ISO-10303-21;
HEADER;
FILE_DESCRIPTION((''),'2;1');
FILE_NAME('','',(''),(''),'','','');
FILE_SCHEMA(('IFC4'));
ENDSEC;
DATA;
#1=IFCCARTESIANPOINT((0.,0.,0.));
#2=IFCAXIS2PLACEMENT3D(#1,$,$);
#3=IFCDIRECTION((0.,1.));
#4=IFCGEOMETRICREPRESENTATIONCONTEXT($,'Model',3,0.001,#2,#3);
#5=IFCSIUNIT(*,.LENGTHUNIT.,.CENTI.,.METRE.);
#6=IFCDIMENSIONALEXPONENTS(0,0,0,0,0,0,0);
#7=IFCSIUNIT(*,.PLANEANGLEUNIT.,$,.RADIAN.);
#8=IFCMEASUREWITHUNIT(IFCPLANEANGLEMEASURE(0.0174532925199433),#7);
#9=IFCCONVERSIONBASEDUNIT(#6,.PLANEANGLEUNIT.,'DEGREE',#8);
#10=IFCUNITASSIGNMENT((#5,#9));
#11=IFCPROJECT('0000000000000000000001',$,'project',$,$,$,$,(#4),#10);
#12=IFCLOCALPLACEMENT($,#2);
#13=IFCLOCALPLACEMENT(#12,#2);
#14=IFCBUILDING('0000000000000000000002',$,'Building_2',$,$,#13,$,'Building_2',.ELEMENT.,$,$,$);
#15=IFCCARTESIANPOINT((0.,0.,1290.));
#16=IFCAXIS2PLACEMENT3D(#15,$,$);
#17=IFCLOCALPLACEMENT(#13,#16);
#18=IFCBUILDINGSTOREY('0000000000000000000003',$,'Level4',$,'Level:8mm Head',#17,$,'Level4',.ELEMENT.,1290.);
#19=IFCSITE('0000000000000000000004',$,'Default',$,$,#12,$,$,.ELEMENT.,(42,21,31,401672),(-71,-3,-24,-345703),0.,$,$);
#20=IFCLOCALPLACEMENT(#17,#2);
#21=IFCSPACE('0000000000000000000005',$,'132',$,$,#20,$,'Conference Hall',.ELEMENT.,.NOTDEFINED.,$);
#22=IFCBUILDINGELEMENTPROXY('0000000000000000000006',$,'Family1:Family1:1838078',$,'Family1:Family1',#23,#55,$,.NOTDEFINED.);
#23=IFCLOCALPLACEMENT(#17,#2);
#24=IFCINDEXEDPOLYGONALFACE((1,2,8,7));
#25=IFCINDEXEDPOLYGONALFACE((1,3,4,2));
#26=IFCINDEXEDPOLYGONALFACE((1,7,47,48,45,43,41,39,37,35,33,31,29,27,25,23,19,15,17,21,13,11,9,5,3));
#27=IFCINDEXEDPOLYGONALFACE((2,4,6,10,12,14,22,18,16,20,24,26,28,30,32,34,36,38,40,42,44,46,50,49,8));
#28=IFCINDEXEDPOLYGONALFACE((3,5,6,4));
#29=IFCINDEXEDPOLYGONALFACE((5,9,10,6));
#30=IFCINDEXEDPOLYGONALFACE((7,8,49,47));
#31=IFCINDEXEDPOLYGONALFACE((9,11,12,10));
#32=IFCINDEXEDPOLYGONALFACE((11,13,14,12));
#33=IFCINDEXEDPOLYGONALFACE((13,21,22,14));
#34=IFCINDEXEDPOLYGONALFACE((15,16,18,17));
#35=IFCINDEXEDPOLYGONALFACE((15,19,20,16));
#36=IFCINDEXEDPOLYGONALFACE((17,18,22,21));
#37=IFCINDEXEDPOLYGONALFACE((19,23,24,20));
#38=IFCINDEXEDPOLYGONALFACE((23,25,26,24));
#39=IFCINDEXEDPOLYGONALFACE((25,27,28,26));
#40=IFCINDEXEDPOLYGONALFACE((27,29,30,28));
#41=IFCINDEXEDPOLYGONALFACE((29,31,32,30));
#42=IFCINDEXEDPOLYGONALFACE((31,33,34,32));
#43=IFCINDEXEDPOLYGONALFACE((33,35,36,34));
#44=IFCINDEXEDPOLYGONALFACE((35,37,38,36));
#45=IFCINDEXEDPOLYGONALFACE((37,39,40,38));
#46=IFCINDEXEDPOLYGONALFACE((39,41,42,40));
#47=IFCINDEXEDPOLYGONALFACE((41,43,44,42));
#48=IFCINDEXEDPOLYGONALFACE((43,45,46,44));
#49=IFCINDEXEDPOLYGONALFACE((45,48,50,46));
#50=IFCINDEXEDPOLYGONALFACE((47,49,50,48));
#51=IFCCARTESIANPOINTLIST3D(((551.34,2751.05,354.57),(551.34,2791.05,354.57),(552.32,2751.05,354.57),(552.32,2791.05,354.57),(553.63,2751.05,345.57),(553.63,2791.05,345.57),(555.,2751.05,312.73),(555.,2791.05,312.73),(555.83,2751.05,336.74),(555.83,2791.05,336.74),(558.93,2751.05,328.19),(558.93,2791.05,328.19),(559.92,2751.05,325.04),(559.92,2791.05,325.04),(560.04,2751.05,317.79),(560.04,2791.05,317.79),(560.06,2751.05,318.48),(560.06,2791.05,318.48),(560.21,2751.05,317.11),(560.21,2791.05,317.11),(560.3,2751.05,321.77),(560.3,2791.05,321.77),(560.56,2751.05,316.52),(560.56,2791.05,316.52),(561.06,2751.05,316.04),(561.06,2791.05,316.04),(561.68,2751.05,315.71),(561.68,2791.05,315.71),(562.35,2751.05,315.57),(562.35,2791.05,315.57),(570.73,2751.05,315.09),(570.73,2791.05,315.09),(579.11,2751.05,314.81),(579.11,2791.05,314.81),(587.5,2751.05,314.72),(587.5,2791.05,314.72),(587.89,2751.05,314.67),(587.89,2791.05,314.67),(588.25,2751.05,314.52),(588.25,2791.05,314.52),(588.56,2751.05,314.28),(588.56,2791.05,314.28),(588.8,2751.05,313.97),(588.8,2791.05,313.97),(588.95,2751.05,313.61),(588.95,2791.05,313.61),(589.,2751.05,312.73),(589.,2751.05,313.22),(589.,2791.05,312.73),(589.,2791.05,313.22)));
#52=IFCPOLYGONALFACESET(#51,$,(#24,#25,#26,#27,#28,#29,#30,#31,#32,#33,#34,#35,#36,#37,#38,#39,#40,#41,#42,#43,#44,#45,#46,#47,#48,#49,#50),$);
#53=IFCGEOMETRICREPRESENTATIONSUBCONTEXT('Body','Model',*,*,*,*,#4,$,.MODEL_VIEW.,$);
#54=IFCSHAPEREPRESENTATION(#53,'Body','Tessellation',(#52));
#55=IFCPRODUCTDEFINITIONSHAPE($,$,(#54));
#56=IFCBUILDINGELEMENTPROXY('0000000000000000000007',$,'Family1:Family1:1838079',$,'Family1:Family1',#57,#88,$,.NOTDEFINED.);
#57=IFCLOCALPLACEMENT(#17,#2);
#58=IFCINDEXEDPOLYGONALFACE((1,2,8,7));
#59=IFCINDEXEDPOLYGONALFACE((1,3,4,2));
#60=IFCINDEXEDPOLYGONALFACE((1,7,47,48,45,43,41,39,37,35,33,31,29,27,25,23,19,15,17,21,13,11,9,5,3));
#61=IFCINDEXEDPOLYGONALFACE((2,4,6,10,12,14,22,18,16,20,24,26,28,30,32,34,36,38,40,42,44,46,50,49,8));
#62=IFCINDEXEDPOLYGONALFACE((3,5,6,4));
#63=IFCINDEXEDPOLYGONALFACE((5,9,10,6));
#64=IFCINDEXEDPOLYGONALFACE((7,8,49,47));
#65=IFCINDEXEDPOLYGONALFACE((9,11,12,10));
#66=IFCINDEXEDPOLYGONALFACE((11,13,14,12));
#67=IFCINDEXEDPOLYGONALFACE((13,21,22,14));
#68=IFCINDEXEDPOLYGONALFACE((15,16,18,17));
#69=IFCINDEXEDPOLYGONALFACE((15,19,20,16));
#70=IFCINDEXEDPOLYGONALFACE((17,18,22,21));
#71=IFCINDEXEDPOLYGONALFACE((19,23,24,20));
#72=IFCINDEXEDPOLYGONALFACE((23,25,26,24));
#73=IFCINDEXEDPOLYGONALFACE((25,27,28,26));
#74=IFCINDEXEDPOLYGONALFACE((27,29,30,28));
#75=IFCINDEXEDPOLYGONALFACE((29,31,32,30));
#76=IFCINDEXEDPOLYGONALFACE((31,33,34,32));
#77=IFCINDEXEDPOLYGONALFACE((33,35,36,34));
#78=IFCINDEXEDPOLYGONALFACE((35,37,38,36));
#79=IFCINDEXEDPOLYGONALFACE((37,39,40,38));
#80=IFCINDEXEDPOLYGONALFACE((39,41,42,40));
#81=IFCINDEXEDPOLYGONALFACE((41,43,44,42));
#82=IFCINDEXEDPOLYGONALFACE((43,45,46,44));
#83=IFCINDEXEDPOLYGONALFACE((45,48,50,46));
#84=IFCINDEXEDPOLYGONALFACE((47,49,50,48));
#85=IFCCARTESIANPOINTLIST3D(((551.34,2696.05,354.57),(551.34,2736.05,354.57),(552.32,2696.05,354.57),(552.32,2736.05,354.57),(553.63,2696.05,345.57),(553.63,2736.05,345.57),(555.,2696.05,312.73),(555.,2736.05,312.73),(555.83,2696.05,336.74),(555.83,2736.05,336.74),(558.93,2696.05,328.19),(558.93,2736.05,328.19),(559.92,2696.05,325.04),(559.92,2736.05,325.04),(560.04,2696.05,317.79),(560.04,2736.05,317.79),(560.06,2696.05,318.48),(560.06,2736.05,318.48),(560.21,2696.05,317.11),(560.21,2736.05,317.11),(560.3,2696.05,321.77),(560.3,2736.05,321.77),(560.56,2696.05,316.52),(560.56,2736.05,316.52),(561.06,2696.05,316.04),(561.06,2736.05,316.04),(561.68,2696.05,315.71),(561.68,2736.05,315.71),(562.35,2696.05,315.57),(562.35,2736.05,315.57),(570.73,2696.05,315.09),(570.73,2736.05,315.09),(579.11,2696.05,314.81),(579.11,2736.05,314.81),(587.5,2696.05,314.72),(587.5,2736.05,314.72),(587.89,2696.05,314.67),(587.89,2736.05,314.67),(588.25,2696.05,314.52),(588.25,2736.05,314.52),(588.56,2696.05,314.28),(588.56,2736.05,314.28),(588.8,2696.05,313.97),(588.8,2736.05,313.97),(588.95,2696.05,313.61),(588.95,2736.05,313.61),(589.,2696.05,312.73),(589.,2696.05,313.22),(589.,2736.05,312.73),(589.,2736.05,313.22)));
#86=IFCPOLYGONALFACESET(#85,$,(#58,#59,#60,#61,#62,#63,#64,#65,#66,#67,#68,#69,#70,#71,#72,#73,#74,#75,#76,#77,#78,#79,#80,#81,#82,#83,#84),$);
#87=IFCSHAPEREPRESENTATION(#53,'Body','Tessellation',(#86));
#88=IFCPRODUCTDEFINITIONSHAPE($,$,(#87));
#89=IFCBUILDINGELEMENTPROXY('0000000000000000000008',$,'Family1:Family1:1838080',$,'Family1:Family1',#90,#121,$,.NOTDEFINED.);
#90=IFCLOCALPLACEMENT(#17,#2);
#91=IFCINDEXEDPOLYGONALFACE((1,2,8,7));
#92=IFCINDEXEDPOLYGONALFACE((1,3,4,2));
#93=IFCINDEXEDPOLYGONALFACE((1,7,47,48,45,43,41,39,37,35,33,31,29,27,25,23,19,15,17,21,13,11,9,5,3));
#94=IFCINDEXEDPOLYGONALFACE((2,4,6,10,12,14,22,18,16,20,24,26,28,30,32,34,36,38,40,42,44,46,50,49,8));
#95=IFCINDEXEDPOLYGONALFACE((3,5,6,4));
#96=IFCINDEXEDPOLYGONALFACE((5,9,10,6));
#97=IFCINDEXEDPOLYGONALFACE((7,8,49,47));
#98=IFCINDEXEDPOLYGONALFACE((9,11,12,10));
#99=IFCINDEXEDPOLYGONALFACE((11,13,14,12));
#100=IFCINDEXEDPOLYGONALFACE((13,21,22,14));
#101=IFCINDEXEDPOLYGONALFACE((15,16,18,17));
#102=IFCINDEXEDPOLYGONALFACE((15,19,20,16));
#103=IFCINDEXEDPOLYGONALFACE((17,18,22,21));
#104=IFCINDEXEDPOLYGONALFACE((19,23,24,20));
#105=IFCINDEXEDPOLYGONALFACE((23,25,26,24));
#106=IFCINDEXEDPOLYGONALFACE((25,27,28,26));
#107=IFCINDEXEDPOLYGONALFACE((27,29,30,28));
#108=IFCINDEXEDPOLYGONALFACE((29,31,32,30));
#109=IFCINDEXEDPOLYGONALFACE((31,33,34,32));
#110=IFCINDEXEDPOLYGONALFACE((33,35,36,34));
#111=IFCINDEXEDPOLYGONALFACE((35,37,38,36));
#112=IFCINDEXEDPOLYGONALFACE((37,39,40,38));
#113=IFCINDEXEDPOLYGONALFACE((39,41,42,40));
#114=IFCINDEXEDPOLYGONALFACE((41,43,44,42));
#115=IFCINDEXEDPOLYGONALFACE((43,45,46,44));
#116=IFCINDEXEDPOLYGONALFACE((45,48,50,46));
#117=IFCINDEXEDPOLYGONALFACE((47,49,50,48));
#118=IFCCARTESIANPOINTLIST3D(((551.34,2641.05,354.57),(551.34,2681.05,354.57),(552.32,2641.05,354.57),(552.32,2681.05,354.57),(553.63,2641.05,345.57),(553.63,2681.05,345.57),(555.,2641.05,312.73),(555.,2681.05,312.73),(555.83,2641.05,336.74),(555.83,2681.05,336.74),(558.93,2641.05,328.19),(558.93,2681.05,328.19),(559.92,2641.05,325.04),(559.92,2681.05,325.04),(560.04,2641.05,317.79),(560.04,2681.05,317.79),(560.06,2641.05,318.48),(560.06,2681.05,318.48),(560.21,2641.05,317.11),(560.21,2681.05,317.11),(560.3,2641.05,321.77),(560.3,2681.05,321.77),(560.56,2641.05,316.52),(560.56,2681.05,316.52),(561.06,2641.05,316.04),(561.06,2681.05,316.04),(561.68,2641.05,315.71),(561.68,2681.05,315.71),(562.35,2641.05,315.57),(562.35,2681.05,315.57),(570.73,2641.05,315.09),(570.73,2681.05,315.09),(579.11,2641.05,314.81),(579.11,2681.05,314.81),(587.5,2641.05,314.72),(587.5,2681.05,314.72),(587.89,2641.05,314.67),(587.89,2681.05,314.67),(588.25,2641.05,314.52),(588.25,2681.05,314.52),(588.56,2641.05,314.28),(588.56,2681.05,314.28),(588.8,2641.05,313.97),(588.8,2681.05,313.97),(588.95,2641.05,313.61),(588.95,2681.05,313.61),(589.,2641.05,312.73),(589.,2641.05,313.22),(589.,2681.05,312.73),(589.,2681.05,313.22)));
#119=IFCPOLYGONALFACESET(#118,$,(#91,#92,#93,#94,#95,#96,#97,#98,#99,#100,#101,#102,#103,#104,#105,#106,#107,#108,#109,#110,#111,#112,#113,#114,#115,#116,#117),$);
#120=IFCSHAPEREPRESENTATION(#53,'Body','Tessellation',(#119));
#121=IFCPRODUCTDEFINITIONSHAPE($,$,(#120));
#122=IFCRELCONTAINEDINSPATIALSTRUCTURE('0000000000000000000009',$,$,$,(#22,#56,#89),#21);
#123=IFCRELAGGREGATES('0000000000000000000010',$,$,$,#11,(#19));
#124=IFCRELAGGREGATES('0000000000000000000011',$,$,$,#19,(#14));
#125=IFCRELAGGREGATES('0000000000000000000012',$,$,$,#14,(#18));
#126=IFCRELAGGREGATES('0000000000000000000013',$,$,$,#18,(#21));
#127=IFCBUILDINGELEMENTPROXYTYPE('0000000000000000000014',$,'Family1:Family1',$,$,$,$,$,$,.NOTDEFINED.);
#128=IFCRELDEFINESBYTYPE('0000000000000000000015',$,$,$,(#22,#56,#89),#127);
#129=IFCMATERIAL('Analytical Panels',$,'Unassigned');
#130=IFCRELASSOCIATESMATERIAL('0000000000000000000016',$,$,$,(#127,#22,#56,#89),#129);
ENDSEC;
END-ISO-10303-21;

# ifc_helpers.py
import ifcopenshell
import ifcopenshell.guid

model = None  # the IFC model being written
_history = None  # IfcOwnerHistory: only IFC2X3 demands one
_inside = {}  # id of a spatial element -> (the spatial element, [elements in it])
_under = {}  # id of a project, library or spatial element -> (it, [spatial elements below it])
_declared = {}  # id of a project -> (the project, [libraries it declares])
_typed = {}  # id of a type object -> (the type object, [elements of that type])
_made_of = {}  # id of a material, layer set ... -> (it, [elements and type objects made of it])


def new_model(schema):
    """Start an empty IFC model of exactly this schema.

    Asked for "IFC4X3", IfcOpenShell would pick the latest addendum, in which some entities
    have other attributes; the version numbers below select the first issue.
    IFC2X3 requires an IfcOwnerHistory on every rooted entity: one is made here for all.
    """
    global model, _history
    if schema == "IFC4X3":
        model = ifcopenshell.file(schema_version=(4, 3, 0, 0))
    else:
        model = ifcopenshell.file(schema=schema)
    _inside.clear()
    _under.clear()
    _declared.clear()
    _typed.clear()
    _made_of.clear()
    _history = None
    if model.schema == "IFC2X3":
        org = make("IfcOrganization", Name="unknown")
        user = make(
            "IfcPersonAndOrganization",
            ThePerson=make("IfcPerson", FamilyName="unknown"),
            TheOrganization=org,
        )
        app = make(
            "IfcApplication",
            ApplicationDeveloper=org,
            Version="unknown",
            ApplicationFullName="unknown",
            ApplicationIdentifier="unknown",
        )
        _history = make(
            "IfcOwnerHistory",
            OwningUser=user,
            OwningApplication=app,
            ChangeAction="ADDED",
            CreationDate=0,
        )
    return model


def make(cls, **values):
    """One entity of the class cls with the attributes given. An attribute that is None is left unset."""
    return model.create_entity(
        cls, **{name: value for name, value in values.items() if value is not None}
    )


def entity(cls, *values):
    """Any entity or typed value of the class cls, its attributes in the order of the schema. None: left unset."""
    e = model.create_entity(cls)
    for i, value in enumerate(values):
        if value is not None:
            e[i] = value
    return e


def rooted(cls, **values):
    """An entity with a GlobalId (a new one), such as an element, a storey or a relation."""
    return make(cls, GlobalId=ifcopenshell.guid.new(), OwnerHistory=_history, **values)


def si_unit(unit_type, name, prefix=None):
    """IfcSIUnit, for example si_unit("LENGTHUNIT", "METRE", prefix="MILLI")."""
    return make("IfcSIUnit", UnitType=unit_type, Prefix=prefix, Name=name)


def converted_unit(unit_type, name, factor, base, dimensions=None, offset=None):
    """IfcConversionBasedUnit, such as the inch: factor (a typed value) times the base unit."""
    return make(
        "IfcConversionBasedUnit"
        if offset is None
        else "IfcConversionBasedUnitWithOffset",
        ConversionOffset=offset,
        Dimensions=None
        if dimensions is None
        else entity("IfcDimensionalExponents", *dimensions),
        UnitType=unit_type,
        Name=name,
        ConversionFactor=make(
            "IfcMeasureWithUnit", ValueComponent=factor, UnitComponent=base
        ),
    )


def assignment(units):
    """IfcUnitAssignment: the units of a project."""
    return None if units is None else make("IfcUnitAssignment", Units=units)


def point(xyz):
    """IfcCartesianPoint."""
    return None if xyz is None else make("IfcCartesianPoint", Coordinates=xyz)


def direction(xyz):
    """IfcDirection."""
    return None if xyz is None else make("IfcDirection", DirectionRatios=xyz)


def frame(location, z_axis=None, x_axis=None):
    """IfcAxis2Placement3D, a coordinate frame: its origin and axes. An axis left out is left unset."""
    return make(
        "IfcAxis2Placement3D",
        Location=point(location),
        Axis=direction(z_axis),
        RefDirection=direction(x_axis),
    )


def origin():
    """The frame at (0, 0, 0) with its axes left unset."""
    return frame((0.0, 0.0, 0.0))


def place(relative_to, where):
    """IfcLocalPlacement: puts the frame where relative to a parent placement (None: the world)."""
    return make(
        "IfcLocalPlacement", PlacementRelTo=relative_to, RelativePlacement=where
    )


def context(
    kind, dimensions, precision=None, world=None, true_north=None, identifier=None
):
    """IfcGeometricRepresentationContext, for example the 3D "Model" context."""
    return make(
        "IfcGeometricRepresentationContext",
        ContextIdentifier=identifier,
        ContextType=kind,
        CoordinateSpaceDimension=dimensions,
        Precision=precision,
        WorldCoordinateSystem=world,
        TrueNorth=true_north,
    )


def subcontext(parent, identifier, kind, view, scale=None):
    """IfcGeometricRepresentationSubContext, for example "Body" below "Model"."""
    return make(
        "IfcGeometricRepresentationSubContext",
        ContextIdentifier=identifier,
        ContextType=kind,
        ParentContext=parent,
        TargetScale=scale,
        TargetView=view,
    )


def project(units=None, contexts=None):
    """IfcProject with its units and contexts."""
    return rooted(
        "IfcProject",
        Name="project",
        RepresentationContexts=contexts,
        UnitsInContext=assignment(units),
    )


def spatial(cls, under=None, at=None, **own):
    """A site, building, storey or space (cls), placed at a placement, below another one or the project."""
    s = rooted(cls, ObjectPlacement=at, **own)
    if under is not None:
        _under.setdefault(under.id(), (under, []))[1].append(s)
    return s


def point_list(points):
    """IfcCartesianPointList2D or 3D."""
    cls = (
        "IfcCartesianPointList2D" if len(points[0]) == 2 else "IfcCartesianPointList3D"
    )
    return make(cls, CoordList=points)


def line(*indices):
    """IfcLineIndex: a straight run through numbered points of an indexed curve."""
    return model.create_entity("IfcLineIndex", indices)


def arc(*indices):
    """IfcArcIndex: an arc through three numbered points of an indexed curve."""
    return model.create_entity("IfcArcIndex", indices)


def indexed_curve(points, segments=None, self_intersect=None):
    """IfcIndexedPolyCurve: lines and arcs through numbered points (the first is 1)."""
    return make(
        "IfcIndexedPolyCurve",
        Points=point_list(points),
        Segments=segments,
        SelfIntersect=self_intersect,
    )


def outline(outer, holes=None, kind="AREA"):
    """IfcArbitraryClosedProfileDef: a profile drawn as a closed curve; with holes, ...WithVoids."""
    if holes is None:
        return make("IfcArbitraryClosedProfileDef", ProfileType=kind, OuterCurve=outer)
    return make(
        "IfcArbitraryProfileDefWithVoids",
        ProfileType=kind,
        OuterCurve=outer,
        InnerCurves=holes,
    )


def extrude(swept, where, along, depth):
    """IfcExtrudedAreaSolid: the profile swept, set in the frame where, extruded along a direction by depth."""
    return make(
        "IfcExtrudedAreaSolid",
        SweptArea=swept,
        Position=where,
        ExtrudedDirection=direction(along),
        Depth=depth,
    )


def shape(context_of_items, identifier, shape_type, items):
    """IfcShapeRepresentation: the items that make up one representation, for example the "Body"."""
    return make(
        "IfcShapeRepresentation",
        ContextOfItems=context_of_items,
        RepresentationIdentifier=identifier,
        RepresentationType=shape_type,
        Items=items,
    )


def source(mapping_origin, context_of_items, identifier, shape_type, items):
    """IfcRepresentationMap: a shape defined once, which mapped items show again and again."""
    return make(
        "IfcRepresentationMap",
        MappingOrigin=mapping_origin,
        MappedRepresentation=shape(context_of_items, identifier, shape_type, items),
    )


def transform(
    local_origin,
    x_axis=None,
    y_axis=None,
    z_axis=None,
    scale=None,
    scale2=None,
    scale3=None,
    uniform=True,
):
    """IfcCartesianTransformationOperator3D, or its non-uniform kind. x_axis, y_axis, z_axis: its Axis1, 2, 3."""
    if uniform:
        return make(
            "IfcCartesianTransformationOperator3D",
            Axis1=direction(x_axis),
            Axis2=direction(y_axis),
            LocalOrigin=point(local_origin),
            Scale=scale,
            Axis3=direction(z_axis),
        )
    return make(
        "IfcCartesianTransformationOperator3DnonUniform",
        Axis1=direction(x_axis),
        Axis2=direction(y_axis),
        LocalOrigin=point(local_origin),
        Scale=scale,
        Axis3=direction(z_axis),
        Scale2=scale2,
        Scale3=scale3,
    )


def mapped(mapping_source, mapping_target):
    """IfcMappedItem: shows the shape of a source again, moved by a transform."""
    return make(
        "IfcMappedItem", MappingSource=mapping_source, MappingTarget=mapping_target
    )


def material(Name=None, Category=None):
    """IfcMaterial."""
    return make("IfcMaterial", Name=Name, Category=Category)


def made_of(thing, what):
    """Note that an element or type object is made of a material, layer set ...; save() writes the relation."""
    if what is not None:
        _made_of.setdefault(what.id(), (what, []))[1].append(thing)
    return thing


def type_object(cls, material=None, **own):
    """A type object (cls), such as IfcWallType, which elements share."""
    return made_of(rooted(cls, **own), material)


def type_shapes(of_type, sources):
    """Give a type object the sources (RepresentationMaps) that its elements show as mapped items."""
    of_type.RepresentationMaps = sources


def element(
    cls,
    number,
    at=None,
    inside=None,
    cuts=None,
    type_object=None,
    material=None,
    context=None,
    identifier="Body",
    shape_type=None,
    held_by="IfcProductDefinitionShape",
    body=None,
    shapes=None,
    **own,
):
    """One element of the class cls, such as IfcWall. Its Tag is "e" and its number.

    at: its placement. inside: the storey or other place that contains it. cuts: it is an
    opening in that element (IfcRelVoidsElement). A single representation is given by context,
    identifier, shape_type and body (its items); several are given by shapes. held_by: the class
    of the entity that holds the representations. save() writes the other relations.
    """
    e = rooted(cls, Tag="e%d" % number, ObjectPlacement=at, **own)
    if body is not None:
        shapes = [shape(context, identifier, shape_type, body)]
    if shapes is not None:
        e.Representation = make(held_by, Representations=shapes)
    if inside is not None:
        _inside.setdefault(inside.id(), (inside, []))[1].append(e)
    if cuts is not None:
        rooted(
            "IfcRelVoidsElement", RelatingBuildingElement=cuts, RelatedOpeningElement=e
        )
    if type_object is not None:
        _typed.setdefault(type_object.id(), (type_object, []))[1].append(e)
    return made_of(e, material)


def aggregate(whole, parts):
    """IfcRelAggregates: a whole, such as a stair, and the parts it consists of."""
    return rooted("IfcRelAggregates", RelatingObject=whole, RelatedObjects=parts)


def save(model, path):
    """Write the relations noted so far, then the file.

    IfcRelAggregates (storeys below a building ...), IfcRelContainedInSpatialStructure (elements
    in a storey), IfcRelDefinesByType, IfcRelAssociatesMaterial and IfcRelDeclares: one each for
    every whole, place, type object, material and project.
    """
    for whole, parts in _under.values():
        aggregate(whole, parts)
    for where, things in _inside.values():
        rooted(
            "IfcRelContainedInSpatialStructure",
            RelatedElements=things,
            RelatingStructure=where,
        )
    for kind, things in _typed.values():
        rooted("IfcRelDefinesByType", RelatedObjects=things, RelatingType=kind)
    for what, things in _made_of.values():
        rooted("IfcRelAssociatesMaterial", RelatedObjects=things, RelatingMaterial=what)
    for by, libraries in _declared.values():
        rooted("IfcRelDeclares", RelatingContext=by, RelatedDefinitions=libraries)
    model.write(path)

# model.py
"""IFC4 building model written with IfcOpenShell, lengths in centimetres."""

from ifc_helpers import new_model, entity, si_unit, converted_unit, direction, frame, origin, place, context, subcontext, project, spatial, line, arc, indexed_curve, outline, extrude, source, transform, mapped, material, type_object, type_shapes, element, save


model = new_model("IFC4")

# Units and contexts
model_context = context("Model", 3, precision=0.001, world=origin(), true_north=direction((0.0, 1.0)))
body_context = subcontext(model_context, "Body", "Model", "MODEL_VIEW")
ifc_project = project(units=[si_unit("LENGTHUNIT", "METRE", prefix="CENTI"), converted_unit("PLANEANGLEUNIT", "DEGREE", entity("IfcPlaneAngleMeasure", 0.0174532925199433), si_unit("PLANEANGLEUNIT", "RADIAN"), dimensions=[0, 0, 0, 0, 0, 0, 0])], contexts=[model_context])

# Site, building, storey, space
site_placement = place(None, origin())
site = spatial("IfcSite", under=ifc_project, at=site_placement, Name="Default", CompositionType="ELEMENT", RefLatitude=(42, 21, 31, 401672), RefLongitude=(-71, -3, -24, -345703), RefElevation=0.0)
building_placement = place(site_placement, origin())
building = spatial("IfcBuilding", under=site, at=building_placement, Name="Building_2", LongName="Building_2", CompositionType="ELEMENT")
storey_placement = place(building_placement, frame((0.0, 0.0, 1290.0)))
storey = spatial("IfcBuildingStorey", under=building, at=storey_placement, Name="Level4", ObjectType="Level:8mm Head", LongName="Level4", CompositionType="ELEMENT", Elevation=1290.0)
space_placement = place(storey_placement, origin())
space = spatial("IfcSpace", under=storey, at=space_placement, Name="132", LongName="Conference Hall", CompositionType="ELEMENT", PredefinedType="NOTDEFINED")

# Building element proxies
ifc_material_1 = material(Name="Analytical Panels", Category="Unassigned")
building_element_proxy_type_1 = type_object("IfcBuildingElementProxyType", Name="Family1:Family1", PredefinedType="NOTDEFINED", material=ifc_material_1)
shared_shape_1 = source(origin(), body_context, "Body", "SweptSolid", [
    extrude(outline(indexed_curve([(-11.13, -13.3), (30.87, -13.3), (30.78, -12.32), (17.19, -11.21), (3.93, -8.04), (-0.94, -7.2), (-5.84, -7.76), (-7.84, -7.43), (-8.94, -5.73), (-10.68, 6.74), (-11.98, 19.25), (-12.51, 20.27), (-13.6, 20.61), (-14.09, 20.57)], segments=[line(1, 2, 3), arc(3, 4, 5), arc(5, 6, 7), arc(7, 8, 9), arc(9, 10, 11), arc(11, 12, 13), line(13, 14, 1)], self_intersect=False)), frame((-20.0, 6.72, 12.25), z_axis=(1.0, 0.0, 0.0), x_axis=(0.0, 0.087156, 0.996195)), (0.0, 0.0, 1.0), 40.0),
])
type_shapes(building_element_proxy_type_1, [shared_shape_1])
for number, where, z_axis, x_axis, name in (
    (1, (574.0, 2771.05, 312.73), (0.0, 0.0, 1.0), (0.0, 1.0, 0.0), "Family1:Family1:1838078"),
    (2, (574.0, 2716.05, 312.73), (0.0, 0.0, 1.0), (0.0, 1.0, 0.0), "Family1:Family1:1838079"),
    (3, (574.0, 2661.05, 312.73), (0.0, 0.0, 1.0), (0.0, 1.0, 0.0), "Family1:Family1:1838080"),
):
    element("IfcBuildingElementProxy", number, at=place(space_placement, frame(where, z_axis=z_axis, x_axis=x_axis)), inside=space, type_object=building_element_proxy_type_1, material=ifc_material_1, Name=name, ObjectType="Family1:Family1", PredefinedType="NOTDEFINED", context=body_context, shape_type="MappedRepresentation", body=[
        mapped(shared_shape_1, transform((0.0, 0.0, 0.0), scale=1.0)),
    ])

save(model, "model.ifc")
